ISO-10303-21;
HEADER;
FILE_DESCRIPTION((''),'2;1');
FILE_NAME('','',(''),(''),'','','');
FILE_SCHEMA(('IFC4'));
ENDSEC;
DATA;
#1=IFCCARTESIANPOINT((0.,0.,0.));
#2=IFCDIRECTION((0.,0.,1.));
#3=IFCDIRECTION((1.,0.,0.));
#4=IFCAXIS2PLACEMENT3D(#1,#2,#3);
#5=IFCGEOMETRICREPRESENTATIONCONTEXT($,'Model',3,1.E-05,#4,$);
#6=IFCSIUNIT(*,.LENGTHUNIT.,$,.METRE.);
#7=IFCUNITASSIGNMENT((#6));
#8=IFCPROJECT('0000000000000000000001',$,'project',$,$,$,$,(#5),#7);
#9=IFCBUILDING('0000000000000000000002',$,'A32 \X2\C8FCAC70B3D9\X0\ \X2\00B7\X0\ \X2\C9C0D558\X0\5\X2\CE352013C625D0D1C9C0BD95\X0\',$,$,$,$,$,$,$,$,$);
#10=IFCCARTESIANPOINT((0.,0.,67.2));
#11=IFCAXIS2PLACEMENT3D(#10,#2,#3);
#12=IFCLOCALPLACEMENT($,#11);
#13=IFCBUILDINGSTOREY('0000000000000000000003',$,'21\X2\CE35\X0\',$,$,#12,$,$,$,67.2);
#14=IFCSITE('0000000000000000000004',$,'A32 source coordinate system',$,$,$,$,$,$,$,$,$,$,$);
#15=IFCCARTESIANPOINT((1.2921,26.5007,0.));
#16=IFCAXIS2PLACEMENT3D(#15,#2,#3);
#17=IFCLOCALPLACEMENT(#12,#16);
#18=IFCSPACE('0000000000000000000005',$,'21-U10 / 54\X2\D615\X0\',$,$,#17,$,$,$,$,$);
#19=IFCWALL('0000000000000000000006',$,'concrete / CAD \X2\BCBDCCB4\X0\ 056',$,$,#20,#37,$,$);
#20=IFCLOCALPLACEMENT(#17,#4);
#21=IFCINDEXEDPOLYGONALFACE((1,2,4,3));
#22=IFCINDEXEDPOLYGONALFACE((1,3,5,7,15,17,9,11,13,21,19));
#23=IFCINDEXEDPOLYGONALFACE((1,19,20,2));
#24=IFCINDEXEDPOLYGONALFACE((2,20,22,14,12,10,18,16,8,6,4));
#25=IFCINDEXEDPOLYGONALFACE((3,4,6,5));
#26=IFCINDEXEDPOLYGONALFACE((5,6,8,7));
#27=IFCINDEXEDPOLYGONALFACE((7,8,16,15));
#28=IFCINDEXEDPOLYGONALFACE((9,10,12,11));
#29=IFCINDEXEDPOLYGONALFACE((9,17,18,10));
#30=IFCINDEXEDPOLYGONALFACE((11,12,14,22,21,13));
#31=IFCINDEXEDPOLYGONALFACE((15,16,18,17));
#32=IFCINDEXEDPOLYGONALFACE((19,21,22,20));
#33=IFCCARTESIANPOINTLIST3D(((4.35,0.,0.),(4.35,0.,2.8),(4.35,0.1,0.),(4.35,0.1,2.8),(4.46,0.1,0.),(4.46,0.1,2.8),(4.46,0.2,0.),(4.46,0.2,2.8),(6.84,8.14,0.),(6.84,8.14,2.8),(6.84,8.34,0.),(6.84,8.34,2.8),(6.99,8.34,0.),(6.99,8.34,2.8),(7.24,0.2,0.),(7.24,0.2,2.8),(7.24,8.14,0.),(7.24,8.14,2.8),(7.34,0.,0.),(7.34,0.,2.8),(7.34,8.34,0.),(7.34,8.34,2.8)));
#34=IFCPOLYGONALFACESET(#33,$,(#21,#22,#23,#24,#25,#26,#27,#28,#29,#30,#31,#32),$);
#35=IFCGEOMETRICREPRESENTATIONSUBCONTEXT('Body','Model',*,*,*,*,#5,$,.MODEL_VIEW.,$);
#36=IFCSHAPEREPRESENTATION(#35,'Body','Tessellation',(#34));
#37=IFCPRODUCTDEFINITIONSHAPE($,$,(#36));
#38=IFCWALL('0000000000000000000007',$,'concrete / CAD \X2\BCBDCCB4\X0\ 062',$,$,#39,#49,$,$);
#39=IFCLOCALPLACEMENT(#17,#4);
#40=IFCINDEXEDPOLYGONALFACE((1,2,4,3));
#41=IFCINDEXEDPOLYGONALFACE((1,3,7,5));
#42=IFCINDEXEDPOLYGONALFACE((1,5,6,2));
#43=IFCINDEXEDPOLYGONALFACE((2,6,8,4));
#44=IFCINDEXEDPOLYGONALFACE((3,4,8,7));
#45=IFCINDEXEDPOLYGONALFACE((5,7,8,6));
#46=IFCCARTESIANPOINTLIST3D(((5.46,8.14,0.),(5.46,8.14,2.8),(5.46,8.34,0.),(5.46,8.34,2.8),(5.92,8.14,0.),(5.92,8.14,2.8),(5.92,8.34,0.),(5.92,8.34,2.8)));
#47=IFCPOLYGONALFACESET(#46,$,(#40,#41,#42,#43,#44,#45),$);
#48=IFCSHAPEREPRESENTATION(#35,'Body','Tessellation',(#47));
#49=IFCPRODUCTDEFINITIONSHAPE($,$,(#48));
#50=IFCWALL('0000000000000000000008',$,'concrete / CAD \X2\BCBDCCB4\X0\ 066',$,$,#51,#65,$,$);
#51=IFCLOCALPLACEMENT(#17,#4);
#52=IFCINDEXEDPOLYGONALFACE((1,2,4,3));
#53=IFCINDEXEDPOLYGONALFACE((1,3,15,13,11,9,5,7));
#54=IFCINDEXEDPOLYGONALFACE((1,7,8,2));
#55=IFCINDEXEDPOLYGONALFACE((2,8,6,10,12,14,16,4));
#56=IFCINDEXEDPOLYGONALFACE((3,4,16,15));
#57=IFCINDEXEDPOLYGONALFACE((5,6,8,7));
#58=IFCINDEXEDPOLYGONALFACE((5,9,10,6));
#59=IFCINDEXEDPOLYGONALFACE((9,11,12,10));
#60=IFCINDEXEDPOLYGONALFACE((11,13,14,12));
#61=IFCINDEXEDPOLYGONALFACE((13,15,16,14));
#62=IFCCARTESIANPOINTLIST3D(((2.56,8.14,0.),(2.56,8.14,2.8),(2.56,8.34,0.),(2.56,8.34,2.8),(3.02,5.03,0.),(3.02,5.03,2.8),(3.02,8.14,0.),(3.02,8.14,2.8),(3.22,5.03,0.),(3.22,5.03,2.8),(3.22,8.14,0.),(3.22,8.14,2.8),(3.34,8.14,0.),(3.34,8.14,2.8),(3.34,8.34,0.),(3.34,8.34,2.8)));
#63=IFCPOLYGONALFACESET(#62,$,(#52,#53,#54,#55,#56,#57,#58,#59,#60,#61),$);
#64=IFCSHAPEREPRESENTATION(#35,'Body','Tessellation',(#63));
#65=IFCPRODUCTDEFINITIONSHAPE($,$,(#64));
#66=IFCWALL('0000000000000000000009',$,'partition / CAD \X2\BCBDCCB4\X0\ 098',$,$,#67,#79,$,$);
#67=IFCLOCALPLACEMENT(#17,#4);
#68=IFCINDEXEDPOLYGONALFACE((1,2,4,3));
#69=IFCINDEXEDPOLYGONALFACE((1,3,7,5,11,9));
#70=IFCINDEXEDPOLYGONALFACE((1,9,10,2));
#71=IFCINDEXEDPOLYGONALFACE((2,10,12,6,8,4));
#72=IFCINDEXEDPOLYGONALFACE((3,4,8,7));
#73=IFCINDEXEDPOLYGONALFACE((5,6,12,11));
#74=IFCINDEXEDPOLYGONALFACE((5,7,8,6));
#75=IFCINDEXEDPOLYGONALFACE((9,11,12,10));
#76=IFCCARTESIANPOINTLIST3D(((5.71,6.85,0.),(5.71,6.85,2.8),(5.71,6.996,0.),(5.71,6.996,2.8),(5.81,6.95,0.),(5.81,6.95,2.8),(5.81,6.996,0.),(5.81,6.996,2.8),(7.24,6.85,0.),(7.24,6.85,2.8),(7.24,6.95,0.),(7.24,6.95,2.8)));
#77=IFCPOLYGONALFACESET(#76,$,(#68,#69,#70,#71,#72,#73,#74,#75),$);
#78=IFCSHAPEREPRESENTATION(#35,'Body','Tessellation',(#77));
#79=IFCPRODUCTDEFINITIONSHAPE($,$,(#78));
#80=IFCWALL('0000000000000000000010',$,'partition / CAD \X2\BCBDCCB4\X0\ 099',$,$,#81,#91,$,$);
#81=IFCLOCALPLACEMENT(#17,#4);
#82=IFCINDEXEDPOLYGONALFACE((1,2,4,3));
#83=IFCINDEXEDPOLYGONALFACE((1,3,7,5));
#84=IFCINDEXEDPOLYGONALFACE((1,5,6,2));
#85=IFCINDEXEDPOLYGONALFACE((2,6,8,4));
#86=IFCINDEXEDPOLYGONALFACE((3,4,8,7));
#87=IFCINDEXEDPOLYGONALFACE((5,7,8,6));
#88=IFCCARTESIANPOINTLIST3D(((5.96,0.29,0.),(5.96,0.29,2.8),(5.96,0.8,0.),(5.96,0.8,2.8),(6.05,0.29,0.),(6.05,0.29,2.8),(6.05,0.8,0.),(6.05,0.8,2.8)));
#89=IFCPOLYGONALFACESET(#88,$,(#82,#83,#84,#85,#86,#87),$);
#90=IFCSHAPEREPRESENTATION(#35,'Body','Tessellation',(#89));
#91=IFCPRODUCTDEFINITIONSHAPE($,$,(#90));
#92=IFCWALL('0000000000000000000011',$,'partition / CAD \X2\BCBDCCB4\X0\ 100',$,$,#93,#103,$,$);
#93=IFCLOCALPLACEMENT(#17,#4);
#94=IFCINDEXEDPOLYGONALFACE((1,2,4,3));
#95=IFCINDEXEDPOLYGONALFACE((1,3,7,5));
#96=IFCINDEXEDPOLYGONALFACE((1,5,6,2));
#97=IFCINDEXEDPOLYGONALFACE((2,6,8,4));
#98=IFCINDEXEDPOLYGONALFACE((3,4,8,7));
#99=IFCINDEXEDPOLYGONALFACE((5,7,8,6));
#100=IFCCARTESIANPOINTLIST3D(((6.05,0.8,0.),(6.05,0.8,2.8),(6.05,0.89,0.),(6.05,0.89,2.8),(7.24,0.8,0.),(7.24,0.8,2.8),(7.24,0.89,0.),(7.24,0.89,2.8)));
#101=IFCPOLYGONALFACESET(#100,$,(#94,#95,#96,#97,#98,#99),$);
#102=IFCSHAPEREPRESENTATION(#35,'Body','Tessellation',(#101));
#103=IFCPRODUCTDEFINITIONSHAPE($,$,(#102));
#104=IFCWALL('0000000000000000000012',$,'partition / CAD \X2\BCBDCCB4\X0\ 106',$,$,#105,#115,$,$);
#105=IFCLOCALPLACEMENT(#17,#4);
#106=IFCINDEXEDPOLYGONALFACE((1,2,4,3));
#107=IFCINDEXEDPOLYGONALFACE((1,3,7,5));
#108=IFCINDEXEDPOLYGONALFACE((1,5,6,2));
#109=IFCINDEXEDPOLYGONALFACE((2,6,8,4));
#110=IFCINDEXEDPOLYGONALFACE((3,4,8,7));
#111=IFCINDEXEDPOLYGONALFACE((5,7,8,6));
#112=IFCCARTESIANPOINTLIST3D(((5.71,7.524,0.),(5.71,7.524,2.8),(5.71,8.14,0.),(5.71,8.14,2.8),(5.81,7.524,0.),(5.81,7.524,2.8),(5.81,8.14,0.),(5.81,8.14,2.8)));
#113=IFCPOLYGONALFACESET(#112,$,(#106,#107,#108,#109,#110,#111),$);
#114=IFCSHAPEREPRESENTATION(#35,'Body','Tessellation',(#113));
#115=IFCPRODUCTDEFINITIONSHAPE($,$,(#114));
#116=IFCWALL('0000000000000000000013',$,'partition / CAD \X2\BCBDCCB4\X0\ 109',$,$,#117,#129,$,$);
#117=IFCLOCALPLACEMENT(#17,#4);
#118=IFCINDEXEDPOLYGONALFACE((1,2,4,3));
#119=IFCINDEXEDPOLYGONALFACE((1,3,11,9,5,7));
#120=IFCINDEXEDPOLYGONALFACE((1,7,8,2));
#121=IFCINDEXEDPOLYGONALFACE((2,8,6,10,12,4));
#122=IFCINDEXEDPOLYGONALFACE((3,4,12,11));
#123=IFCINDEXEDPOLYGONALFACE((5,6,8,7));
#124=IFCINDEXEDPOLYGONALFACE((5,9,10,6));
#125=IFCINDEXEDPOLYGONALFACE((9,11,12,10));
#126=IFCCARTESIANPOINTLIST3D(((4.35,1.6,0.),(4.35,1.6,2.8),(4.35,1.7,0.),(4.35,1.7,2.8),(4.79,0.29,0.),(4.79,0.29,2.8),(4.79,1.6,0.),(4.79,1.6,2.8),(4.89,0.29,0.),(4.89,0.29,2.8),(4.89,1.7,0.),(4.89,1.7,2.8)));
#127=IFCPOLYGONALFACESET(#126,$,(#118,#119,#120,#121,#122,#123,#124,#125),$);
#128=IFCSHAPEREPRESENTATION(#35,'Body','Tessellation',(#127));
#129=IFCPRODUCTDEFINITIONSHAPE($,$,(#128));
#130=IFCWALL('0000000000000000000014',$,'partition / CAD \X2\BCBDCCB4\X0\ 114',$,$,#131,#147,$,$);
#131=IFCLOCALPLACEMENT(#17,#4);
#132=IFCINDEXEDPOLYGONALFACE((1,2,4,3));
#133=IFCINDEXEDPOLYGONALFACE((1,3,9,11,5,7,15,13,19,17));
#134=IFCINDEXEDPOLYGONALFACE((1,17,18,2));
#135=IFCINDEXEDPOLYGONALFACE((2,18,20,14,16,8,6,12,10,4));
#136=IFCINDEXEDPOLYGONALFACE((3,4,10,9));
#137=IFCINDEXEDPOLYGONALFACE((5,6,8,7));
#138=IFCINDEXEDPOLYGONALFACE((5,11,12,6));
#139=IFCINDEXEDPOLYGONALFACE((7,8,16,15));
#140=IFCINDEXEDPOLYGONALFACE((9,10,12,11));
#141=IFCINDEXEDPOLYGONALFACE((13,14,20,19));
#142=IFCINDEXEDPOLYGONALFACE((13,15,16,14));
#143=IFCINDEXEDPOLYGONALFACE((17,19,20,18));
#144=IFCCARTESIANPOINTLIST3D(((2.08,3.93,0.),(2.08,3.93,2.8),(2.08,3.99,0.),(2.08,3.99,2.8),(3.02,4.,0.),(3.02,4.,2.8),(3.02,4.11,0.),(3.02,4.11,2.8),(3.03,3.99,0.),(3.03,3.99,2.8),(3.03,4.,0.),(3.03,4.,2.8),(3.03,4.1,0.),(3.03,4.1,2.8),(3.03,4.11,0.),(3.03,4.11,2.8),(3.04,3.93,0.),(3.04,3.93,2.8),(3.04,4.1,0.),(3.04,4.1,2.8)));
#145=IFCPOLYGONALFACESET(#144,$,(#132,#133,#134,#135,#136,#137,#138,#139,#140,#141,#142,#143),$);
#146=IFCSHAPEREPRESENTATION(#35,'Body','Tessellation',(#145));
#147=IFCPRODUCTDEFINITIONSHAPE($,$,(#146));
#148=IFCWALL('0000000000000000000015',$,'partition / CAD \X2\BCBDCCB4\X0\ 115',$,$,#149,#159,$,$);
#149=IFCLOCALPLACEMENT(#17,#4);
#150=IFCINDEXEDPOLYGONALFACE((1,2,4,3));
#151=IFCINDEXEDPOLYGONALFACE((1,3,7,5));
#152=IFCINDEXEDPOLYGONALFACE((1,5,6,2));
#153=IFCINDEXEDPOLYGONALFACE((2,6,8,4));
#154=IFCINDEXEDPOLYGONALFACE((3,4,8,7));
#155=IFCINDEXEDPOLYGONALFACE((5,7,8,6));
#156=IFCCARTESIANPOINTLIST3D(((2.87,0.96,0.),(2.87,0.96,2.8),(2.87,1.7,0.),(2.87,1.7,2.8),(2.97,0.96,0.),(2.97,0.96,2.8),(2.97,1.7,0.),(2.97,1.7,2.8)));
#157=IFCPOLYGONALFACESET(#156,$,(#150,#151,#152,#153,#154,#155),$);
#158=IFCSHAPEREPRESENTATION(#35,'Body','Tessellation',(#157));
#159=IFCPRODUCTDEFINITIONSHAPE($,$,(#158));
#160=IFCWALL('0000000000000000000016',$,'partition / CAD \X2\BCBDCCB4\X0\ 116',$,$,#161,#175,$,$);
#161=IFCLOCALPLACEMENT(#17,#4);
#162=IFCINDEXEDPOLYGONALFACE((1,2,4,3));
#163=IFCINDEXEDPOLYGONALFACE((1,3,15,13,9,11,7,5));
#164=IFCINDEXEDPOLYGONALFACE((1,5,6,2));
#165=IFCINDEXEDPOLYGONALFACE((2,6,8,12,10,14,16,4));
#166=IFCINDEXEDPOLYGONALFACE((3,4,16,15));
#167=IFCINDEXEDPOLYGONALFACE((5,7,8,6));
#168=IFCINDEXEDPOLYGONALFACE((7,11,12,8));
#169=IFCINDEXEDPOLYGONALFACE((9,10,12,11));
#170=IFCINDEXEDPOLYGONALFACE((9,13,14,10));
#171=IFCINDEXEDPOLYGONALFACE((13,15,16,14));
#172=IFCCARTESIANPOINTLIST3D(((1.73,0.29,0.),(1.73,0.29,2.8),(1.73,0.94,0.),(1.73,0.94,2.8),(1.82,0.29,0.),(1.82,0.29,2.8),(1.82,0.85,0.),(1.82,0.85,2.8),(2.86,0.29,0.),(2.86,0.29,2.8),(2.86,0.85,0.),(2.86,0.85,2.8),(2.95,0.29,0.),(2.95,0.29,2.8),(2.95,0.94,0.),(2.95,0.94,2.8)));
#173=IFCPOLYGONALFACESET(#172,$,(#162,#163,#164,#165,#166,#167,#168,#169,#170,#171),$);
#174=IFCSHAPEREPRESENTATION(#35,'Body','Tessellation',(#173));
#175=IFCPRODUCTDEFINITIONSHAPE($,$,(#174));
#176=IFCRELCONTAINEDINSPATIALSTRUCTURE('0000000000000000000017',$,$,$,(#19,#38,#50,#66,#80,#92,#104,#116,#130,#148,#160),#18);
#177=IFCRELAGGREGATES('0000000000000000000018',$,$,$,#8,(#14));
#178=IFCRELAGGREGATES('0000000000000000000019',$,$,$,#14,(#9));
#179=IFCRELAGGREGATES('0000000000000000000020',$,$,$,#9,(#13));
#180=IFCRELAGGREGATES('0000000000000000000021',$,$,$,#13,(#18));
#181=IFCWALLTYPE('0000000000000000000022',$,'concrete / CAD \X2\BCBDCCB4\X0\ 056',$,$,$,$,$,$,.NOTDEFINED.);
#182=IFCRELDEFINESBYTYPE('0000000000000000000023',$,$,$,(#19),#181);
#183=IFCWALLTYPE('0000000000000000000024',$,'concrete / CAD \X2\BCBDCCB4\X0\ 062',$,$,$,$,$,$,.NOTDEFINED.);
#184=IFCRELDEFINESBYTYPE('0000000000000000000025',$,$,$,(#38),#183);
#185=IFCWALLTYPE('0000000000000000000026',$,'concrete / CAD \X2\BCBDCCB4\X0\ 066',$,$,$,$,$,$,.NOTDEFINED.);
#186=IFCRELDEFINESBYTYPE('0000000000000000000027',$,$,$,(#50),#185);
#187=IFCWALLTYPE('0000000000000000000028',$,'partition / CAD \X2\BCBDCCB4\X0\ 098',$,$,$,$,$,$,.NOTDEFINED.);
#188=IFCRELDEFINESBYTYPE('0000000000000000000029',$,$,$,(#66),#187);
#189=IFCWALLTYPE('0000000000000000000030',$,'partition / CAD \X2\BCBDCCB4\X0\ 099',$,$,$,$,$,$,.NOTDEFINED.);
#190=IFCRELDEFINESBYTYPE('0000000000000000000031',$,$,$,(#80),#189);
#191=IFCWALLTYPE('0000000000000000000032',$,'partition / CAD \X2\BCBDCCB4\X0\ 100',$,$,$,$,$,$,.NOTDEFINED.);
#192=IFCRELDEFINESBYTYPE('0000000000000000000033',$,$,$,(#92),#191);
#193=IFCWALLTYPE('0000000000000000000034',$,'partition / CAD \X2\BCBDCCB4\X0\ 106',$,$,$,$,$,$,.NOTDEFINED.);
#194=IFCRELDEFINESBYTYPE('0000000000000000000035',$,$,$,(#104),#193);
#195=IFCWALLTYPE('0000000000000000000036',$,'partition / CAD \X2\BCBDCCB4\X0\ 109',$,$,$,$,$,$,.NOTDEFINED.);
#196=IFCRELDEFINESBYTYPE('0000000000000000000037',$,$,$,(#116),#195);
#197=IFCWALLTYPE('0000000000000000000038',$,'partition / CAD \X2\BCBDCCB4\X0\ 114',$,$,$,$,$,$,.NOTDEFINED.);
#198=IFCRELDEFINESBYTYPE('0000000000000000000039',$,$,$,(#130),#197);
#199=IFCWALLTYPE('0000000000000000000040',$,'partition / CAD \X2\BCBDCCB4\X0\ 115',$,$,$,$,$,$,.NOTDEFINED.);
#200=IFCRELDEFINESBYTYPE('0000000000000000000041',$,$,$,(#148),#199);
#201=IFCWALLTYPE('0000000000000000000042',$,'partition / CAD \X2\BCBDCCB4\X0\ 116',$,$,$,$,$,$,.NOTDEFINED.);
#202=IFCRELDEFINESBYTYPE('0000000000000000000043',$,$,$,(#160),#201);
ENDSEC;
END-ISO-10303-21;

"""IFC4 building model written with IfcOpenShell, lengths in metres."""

from ifc_helpers import new_model, si_unit, frame, origin, origin_with_axes, place, context, subcontext, project, spatial, polyline, outline, extrude, source, transform, mapped, type_object, type_shapes, element, save


model = new_model("IFC4")

# Units and contexts
model_context = context("Model", 3, precision=1e-05, world=origin_with_axes())
body_context = subcontext(model_context, "Body", "Model", "MODEL_VIEW")
ifc_project = project(units=[si_unit("LENGTHUNIT", "METRE")], contexts=[model_context])

# Site, building, storey, space
site = spatial("IfcSite", under=ifc_project, Name="A32 source coordinate system")
building = spatial("IfcBuilding", under=site, Name="A32 주거동 · 지하5층–옥탑지붕")
storey_placement = place(None, frame((0.0, 0.0, 67.2), z_axis=(0.0, 0.0, 1.0), x_axis=(1.0, 0.0, 0.0)))
storey = spatial("IfcBuildingStorey", under=building, at=storey_placement, Name="21층", Elevation=67.2)
space_placement = place(storey_placement, frame((1.2921, 26.5007, 0.0), z_axis=(0.0, 0.0, 1.0), x_axis=(1.0, 0.0, 0.0)))
space = spatial("IfcSpace", under=storey, at=space_placement, Name="21-U10 / 54형")

# Walls
wall_type_1 = type_object("IfcWallType", Name="concrete / CAD 벽체 056", PredefinedType="NOTDEFINED")
shared_shape_1 = source(origin(), body_context, "Body", "SweptSolid", [
    extrude(outline(polyline([(7.24, 0.2), (7.24, 8.14), (6.84, 8.14), (6.84, 8.34), (6.99, 8.34), (6.99, 8.34), (7.34, 8.34), (7.34, 0.0), (4.35, 0.0), (4.35, 0.1), (4.46, 0.1), (4.46, 0.2), (7.24, 0.2)])), origin(), (0.0, 0.0, 1.0), 2.8),
])
type_shapes(wall_type_1, [shared_shape_1])
wall_1_placement = place(space_placement, origin_with_axes())
element("IfcWall", 1, at=wall_1_placement, inside=space, type_object=wall_type_1, Name="concrete / CAD 벽체 056", context=body_context, shape_type="MappedRepresentation", body=[
    mapped(shared_shape_1, transform((0.0, 0.0, 0.0), scale=1.0)),
])
wall_type_2 = type_object("IfcWallType", Name="concrete / CAD 벽체 062", PredefinedType="NOTDEFINED")
shared_shape_2 = source(origin(), body_context, "Body", "SweptSolid", [
    extrude(outline(polyline([(5.46, 8.14), (5.46, 8.34), (5.92, 8.34), (5.92, 8.14), (5.46, 8.14)])), origin(), (0.0, 0.0, 1.0), 2.8),
])
type_shapes(wall_type_2, [shared_shape_2])
wall_2_placement = place(space_placement, origin_with_axes())
element("IfcWall", 2, at=wall_2_placement, inside=space, type_object=wall_type_2, Name="concrete / CAD 벽체 062", context=body_context, shape_type="MappedRepresentation", body=[
    mapped(shared_shape_2, transform((0.0, 0.0, 0.0), scale=1.0)),
])
wall_type_3 = type_object("IfcWallType", Name="concrete / CAD 벽체 066", PredefinedType="NOTDEFINED")
shared_shape_3 = source(origin(), body_context, "Body", "SweptSolid", [
    extrude(outline(polyline([(3.22, 8.14), (3.22, 5.03), (3.02, 5.03), (3.02, 8.14), (2.56, 8.14), (2.56, 8.34), (3.34, 8.34), (3.34, 8.14), (3.22, 8.14)])), origin(), (0.0, 0.0, 1.0), 2.8),
])
type_shapes(wall_type_3, [shared_shape_3])
wall_3_placement = place(space_placement, origin_with_axes())
element("IfcWall", 3, at=wall_3_placement, inside=space, type_object=wall_type_3, Name="concrete / CAD 벽체 066", context=body_context, shape_type="MappedRepresentation", body=[
    mapped(shared_shape_3, transform((0.0, 0.0, 0.0), scale=1.0)),
])
wall_type_4 = type_object("IfcWallType", Name="partition / CAD 벽체 098", PredefinedType="NOTDEFINED")
shared_shape_4 = source(origin(), body_context, "Body", "SweptSolid", [
    extrude(outline(polyline([(5.71, 6.996), (5.81, 6.996), (5.81, 6.95), (7.24, 6.95), (7.24, 6.85), (5.71, 6.85), (5.71, 6.996)])), origin(), (0.0, 0.0, 1.0), 2.8),
])
type_shapes(wall_type_4, [shared_shape_4])
wall_4_placement = place(space_placement, origin_with_axes())
element("IfcWall", 4, at=wall_4_placement, inside=space, type_object=wall_type_4, Name="partition / CAD 벽체 098", context=body_context, shape_type="MappedRepresentation", body=[
    mapped(shared_shape_4, transform((0.0, 0.0, 0.0), scale=1.0)),
])
wall_type_5 = type_object("IfcWallType", Name="partition / CAD 벽체 099", PredefinedType="NOTDEFINED")
shared_shape_5 = source(origin(), body_context, "Body", "SweptSolid", [
    extrude(outline(polyline([(6.05, 0.8), (6.05, 0.29), (5.96, 0.29), (5.96, 0.8), (6.05, 0.8)])), origin(), (0.0, 0.0, 1.0), 2.8),
])
type_shapes(wall_type_5, [shared_shape_5])
wall_5_placement = place(space_placement, origin_with_axes())
element("IfcWall", 5, at=wall_5_placement, inside=space, type_object=wall_type_5, Name="partition / CAD 벽체 099", context=body_context, shape_type="MappedRepresentation", body=[
    mapped(shared_shape_5, transform((0.0, 0.0, 0.0), scale=1.0)),
])
wall_type_6 = type_object("IfcWallType", Name="partition / CAD 벽체 100", PredefinedType="NOTDEFINED")
shared_shape_6 = source(origin(), body_context, "Body", "SweptSolid", [
    extrude(outline(polyline([(7.24, 0.8), (6.05, 0.8), (6.05, 0.89), (7.24, 0.89), (7.24, 0.8)])), origin(), (0.0, 0.0, 1.0), 2.8),
])
type_shapes(wall_type_6, [shared_shape_6])
wall_6_placement = place(space_placement, origin_with_axes())
element("IfcWall", 6, at=wall_6_placement, inside=space, type_object=wall_type_6, Name="partition / CAD 벽체 100", context=body_context, shape_type="MappedRepresentation", body=[
    mapped(shared_shape_6, transform((0.0, 0.0, 0.0), scale=1.0)),
])
wall_type_7 = type_object("IfcWallType", Name="partition / CAD 벽체 106", PredefinedType="NOTDEFINED")
shared_shape_7 = source(origin(), body_context, "Body", "SweptSolid", [
    extrude(outline(polyline([(5.71, 8.14), (5.81, 8.14), (5.81, 7.524), (5.71, 7.524), (5.71, 8.14)])), origin(), (0.0, 0.0, 1.0), 2.8),
])
type_shapes(wall_type_7, [shared_shape_7])
wall_7_placement = place(space_placement, origin_with_axes())
element("IfcWall", 7, at=wall_7_placement, inside=space, type_object=wall_type_7, Name="partition / CAD 벽체 106", context=body_context, shape_type="MappedRepresentation", body=[
    mapped(shared_shape_7, transform((0.0, 0.0, 0.0), scale=1.0)),
])
wall_type_8 = type_object("IfcWallType", Name="partition / CAD 벽체 109", PredefinedType="NOTDEFINED")
shared_shape_8 = source(origin(), body_context, "Body", "SweptSolid", [
    extrude(outline(polyline([(4.79, 1.6), (4.35, 1.6), (4.35, 1.7), (4.89, 1.7), (4.89, 0.29), (4.79, 0.29), (4.79, 1.6)])), origin(), (0.0, 0.0, 1.0), 2.8),
])
type_shapes(wall_type_8, [shared_shape_8])
wall_8_placement = place(space_placement, origin_with_axes())
element("IfcWall", 8, at=wall_8_placement, inside=space, type_object=wall_type_8, Name="partition / CAD 벽체 109", context=body_context, shape_type="MappedRepresentation", body=[
    mapped(shared_shape_8, transform((0.0, 0.0, 0.0), scale=1.0)),
])
wall_type_9 = type_object("IfcWallType", Name="partition / CAD 벽체 114", PredefinedType="NOTDEFINED")
shared_shape_9 = source(origin(), body_context, "Body", "SweptSolid", [
    extrude(outline(polyline([(2.08, 3.99), (3.03, 3.99), (3.03, 4.0), (3.02, 4.0), (3.02, 4.11), (3.03, 4.11), (3.03, 4.1), (3.04, 4.1), (3.04, 3.93), (2.08, 3.93), (2.08, 3.99)])), origin(), (0.0, 0.0, 1.0), 2.8),
])
type_shapes(wall_type_9, [shared_shape_9])
wall_9_placement = place(space_placement, origin_with_axes())
element("IfcWall", 9, at=wall_9_placement, inside=space, type_object=wall_type_9, Name="partition / CAD 벽체 114", context=body_context, shape_type="MappedRepresentation", body=[
    mapped(shared_shape_9, transform((0.0, 0.0, 0.0), scale=1.0)),
])
wall_type_10 = type_object("IfcWallType", Name="partition / CAD 벽체 115", PredefinedType="NOTDEFINED")
shared_shape_10 = source(origin(), body_context, "Body", "SweptSolid", [
    extrude(outline(polyline([(2.87, 1.7), (2.97, 1.7), (2.97, 0.96), (2.87, 0.96), (2.87, 1.7)])), origin(), (0.0, 0.0, 1.0), 2.8),
])
type_shapes(wall_type_10, [shared_shape_10])
wall_10_placement = place(space_placement, origin_with_axes())
element("IfcWall", 10, at=wall_10_placement, inside=space, type_object=wall_type_10, Name="partition / CAD 벽체 115", context=body_context, shape_type="MappedRepresentation", body=[
    mapped(shared_shape_10, transform((0.0, 0.0, 0.0), scale=1.0)),
])
wall_type_11 = type_object("IfcWallType", Name="partition / CAD 벽체 116", PredefinedType="NOTDEFINED")
shared_shape_11 = source(origin(), body_context, "Body", "SweptSolid", [
    extrude(outline(polyline([(2.95, 0.29), (2.86, 0.29), (2.86, 0.85), (1.82, 0.85), (1.82, 0.29), (1.73, 0.29), (1.73, 0.94), (2.95, 0.94), (2.95, 0.29)])), origin(), (0.0, 0.0, 1.0), 2.8),
])
type_shapes(wall_type_11, [shared_shape_11])
wall_11_placement = place(space_placement, origin_with_axes())
element("IfcWall", 11, at=wall_11_placement, inside=space, type_object=wall_type_11, Name="partition / CAD 벽체 116", context=body_context, shape_type="MappedRepresentation", body=[
    mapped(shared_shape_11, transform((0.0, 0.0, 0.0), scale=1.0)),
])

save(model, "model.ifc")
